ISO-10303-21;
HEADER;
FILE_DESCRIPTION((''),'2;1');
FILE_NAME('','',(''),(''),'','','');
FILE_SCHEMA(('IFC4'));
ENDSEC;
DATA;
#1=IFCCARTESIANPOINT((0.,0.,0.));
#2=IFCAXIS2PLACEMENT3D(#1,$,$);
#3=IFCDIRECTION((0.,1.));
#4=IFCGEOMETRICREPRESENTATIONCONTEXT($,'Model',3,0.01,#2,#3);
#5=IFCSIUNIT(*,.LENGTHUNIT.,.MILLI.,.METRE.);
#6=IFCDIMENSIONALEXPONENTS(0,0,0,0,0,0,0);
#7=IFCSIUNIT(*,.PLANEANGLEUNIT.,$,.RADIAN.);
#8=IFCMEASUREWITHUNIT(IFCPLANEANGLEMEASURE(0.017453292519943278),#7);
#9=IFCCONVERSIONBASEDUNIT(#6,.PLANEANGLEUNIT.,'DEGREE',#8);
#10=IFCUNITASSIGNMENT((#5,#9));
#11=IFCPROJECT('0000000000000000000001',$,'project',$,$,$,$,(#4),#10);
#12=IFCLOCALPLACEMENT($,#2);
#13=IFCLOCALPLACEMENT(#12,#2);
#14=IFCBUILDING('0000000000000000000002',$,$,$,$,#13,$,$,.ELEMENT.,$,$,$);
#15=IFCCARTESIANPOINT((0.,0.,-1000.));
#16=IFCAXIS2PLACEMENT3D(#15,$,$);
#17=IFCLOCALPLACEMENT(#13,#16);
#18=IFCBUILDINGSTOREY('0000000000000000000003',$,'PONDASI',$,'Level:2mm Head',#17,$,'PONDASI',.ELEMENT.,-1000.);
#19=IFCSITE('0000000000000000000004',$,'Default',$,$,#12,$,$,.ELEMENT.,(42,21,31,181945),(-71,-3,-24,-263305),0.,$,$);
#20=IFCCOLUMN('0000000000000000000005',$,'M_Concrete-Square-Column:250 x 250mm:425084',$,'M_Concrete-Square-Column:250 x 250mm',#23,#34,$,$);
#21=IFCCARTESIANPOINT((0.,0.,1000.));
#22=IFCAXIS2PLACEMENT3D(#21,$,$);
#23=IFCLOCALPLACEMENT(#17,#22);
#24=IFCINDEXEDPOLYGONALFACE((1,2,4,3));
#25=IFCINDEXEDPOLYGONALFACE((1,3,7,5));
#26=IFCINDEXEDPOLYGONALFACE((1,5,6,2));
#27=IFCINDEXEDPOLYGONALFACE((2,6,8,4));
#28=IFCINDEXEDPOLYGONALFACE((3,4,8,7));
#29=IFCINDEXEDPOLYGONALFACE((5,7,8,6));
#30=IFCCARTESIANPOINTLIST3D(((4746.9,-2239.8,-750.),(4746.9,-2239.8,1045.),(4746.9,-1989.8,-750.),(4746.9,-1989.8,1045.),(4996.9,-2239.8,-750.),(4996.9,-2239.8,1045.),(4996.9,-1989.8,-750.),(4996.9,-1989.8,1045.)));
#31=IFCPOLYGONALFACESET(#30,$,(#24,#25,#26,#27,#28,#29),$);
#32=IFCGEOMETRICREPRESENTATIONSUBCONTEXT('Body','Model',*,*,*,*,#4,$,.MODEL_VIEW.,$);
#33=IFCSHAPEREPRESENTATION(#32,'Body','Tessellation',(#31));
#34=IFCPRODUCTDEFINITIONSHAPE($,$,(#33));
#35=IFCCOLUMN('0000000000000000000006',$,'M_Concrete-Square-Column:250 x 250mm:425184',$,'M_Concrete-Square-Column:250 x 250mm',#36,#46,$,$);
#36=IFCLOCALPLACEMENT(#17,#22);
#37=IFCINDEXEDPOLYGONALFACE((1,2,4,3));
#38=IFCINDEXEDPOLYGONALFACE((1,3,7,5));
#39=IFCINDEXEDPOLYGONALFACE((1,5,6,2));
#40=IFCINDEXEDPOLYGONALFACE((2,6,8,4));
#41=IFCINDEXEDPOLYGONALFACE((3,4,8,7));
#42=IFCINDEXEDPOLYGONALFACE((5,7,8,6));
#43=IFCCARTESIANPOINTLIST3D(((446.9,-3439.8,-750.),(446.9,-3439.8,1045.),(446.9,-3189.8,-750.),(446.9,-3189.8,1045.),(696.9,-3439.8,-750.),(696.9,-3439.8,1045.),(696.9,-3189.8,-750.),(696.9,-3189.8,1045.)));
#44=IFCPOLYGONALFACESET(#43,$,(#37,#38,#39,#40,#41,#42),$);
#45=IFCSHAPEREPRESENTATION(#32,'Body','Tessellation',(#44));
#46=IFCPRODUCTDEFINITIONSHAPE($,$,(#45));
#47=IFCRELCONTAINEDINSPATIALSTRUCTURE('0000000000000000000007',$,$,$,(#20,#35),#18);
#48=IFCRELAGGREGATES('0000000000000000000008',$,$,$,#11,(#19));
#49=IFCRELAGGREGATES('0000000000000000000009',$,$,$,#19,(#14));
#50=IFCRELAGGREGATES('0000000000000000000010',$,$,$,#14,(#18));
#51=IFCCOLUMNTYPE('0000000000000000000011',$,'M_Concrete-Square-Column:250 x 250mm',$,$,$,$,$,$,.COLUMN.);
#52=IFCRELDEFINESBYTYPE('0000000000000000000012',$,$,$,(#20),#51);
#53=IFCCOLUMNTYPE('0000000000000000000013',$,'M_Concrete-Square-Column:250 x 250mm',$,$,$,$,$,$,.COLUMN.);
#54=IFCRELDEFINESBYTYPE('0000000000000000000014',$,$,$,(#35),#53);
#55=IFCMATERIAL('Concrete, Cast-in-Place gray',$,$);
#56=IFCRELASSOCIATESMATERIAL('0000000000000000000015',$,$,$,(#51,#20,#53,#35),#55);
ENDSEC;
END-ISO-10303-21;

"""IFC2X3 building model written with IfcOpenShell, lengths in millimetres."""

from ifc_helpers import new_model, entity, si_unit, converted_unit, direction, frame, frame_2d, origin, origin_2d_with_axis, place, context, subcontext, project, spatial, rectangle, extrude, source, transform, mapped, material, type_object, type_shapes, element, save


model = new_model("IFC2X3")

# Units and contexts
model_context = context("Model", 3, precision=0.01, world=origin(), true_north=direction((0.0, 1.0)))
body_context = subcontext(model_context, "Body", "Model", "MODEL_VIEW")
ifc_project = project(units=[si_unit("LENGTHUNIT", "METRE", prefix="MILLI"), converted_unit("PLANEANGLEUNIT", "DEGREE", entity("IfcPlaneAngleMeasure", 0.017453292519943278), si_unit("PLANEANGLEUNIT", "RADIAN"), dimensions=[0, 0, 0, 0, 0, 0, 0])], contexts=[model_context])

# Site, building, storey
site_placement = place(None, origin())
site = spatial("IfcSite", under=ifc_project, at=site_placement, Name="Default", CompositionType="ELEMENT", RefLatitude=(42, 21, 31, 181945), RefLongitude=(-71, -3, -24, -263305), RefElevation=0.0)
building_placement = place(site_placement, origin())
building = spatial("IfcBuilding", under=site, at=building_placement, CompositionType="ELEMENT")
storey_placement = place(building_placement, frame((0.0, 0.0, -1000.0)))
storey = spatial("IfcBuildingStorey", under=building, at=storey_placement, Name="PONDASI", ObjectType="Level:2mm Head", LongName="PONDASI", CompositionType="ELEMENT", Elevation=-1000.0)

# Columns
ifc_material_1 = material(Name="Concrete, Cast-in-Place gray")
column_type_1 = type_object("IfcColumnType", Name="M_Concrete-Square-Column:250 x 250mm", PredefinedType="COLUMN", material=ifc_material_1)
shared_shape_1 = source(origin(), body_context, "Body", "SweptSolid", [
    extrude(rectangle(XDim=250.0, YDim=250.0, at=origin_2d_with_axis()), frame((4871.9, -2114.8, -750.0), z_axis=(0.0, 0.0, 1.0), x_axis=(-1.0, 0.0, 0.0)), (0.0, 0.0, 1.0), 1795.0),
])
type_shapes(column_type_1, [shared_shape_1])
column_1_placement = place(storey_placement, frame((0.0, 0.0, 1000.0)))
element("IfcColumn", 1, at=column_1_placement, inside=storey, type_object=column_type_1, material=ifc_material_1, Name="M_Concrete-Square-Column:250 x 250mm:425084", ObjectType="M_Concrete-Square-Column:250 x 250mm", context=body_context, shape_type="MappedRepresentation", body=[
    mapped(shared_shape_1, transform((0.0, 0.0, 0.0), scale=1.0)),
])
column_type_2 = type_object("IfcColumnType", Name="M_Concrete-Square-Column:250 x 250mm", PredefinedType="COLUMN", material=ifc_material_1)
shared_shape_2 = source(origin(), body_context, "Body", "SweptSolid", [
    extrude(rectangle(XDim=250.0, YDim=250.0, at=frame_2d((0.0, 0.0), x_axis=(1.0, 0.0))), frame((571.9, -3314.8, -750.0), z_axis=(0.0, 0.0, 1.0), x_axis=(-1.0, 0.0, 0.0)), (0.0, 0.0, 1.0), 1795.0),
])
type_shapes(column_type_2, [shared_shape_2])
column_2_placement = place(storey_placement, frame((0.0, 0.0, 1000.0)))
element("IfcColumn", 2, at=column_2_placement, inside=storey, type_object=column_type_2, material=ifc_material_1, Name="M_Concrete-Square-Column:250 x 250mm:425184", ObjectType="M_Concrete-Square-Column:250 x 250mm", context=body_context, shape_type="MappedRepresentation", body=[
    mapped(shared_shape_2, transform((0.0, 0.0, 0.0), scale=1.0)),
])

save(model, "model.ifc")
